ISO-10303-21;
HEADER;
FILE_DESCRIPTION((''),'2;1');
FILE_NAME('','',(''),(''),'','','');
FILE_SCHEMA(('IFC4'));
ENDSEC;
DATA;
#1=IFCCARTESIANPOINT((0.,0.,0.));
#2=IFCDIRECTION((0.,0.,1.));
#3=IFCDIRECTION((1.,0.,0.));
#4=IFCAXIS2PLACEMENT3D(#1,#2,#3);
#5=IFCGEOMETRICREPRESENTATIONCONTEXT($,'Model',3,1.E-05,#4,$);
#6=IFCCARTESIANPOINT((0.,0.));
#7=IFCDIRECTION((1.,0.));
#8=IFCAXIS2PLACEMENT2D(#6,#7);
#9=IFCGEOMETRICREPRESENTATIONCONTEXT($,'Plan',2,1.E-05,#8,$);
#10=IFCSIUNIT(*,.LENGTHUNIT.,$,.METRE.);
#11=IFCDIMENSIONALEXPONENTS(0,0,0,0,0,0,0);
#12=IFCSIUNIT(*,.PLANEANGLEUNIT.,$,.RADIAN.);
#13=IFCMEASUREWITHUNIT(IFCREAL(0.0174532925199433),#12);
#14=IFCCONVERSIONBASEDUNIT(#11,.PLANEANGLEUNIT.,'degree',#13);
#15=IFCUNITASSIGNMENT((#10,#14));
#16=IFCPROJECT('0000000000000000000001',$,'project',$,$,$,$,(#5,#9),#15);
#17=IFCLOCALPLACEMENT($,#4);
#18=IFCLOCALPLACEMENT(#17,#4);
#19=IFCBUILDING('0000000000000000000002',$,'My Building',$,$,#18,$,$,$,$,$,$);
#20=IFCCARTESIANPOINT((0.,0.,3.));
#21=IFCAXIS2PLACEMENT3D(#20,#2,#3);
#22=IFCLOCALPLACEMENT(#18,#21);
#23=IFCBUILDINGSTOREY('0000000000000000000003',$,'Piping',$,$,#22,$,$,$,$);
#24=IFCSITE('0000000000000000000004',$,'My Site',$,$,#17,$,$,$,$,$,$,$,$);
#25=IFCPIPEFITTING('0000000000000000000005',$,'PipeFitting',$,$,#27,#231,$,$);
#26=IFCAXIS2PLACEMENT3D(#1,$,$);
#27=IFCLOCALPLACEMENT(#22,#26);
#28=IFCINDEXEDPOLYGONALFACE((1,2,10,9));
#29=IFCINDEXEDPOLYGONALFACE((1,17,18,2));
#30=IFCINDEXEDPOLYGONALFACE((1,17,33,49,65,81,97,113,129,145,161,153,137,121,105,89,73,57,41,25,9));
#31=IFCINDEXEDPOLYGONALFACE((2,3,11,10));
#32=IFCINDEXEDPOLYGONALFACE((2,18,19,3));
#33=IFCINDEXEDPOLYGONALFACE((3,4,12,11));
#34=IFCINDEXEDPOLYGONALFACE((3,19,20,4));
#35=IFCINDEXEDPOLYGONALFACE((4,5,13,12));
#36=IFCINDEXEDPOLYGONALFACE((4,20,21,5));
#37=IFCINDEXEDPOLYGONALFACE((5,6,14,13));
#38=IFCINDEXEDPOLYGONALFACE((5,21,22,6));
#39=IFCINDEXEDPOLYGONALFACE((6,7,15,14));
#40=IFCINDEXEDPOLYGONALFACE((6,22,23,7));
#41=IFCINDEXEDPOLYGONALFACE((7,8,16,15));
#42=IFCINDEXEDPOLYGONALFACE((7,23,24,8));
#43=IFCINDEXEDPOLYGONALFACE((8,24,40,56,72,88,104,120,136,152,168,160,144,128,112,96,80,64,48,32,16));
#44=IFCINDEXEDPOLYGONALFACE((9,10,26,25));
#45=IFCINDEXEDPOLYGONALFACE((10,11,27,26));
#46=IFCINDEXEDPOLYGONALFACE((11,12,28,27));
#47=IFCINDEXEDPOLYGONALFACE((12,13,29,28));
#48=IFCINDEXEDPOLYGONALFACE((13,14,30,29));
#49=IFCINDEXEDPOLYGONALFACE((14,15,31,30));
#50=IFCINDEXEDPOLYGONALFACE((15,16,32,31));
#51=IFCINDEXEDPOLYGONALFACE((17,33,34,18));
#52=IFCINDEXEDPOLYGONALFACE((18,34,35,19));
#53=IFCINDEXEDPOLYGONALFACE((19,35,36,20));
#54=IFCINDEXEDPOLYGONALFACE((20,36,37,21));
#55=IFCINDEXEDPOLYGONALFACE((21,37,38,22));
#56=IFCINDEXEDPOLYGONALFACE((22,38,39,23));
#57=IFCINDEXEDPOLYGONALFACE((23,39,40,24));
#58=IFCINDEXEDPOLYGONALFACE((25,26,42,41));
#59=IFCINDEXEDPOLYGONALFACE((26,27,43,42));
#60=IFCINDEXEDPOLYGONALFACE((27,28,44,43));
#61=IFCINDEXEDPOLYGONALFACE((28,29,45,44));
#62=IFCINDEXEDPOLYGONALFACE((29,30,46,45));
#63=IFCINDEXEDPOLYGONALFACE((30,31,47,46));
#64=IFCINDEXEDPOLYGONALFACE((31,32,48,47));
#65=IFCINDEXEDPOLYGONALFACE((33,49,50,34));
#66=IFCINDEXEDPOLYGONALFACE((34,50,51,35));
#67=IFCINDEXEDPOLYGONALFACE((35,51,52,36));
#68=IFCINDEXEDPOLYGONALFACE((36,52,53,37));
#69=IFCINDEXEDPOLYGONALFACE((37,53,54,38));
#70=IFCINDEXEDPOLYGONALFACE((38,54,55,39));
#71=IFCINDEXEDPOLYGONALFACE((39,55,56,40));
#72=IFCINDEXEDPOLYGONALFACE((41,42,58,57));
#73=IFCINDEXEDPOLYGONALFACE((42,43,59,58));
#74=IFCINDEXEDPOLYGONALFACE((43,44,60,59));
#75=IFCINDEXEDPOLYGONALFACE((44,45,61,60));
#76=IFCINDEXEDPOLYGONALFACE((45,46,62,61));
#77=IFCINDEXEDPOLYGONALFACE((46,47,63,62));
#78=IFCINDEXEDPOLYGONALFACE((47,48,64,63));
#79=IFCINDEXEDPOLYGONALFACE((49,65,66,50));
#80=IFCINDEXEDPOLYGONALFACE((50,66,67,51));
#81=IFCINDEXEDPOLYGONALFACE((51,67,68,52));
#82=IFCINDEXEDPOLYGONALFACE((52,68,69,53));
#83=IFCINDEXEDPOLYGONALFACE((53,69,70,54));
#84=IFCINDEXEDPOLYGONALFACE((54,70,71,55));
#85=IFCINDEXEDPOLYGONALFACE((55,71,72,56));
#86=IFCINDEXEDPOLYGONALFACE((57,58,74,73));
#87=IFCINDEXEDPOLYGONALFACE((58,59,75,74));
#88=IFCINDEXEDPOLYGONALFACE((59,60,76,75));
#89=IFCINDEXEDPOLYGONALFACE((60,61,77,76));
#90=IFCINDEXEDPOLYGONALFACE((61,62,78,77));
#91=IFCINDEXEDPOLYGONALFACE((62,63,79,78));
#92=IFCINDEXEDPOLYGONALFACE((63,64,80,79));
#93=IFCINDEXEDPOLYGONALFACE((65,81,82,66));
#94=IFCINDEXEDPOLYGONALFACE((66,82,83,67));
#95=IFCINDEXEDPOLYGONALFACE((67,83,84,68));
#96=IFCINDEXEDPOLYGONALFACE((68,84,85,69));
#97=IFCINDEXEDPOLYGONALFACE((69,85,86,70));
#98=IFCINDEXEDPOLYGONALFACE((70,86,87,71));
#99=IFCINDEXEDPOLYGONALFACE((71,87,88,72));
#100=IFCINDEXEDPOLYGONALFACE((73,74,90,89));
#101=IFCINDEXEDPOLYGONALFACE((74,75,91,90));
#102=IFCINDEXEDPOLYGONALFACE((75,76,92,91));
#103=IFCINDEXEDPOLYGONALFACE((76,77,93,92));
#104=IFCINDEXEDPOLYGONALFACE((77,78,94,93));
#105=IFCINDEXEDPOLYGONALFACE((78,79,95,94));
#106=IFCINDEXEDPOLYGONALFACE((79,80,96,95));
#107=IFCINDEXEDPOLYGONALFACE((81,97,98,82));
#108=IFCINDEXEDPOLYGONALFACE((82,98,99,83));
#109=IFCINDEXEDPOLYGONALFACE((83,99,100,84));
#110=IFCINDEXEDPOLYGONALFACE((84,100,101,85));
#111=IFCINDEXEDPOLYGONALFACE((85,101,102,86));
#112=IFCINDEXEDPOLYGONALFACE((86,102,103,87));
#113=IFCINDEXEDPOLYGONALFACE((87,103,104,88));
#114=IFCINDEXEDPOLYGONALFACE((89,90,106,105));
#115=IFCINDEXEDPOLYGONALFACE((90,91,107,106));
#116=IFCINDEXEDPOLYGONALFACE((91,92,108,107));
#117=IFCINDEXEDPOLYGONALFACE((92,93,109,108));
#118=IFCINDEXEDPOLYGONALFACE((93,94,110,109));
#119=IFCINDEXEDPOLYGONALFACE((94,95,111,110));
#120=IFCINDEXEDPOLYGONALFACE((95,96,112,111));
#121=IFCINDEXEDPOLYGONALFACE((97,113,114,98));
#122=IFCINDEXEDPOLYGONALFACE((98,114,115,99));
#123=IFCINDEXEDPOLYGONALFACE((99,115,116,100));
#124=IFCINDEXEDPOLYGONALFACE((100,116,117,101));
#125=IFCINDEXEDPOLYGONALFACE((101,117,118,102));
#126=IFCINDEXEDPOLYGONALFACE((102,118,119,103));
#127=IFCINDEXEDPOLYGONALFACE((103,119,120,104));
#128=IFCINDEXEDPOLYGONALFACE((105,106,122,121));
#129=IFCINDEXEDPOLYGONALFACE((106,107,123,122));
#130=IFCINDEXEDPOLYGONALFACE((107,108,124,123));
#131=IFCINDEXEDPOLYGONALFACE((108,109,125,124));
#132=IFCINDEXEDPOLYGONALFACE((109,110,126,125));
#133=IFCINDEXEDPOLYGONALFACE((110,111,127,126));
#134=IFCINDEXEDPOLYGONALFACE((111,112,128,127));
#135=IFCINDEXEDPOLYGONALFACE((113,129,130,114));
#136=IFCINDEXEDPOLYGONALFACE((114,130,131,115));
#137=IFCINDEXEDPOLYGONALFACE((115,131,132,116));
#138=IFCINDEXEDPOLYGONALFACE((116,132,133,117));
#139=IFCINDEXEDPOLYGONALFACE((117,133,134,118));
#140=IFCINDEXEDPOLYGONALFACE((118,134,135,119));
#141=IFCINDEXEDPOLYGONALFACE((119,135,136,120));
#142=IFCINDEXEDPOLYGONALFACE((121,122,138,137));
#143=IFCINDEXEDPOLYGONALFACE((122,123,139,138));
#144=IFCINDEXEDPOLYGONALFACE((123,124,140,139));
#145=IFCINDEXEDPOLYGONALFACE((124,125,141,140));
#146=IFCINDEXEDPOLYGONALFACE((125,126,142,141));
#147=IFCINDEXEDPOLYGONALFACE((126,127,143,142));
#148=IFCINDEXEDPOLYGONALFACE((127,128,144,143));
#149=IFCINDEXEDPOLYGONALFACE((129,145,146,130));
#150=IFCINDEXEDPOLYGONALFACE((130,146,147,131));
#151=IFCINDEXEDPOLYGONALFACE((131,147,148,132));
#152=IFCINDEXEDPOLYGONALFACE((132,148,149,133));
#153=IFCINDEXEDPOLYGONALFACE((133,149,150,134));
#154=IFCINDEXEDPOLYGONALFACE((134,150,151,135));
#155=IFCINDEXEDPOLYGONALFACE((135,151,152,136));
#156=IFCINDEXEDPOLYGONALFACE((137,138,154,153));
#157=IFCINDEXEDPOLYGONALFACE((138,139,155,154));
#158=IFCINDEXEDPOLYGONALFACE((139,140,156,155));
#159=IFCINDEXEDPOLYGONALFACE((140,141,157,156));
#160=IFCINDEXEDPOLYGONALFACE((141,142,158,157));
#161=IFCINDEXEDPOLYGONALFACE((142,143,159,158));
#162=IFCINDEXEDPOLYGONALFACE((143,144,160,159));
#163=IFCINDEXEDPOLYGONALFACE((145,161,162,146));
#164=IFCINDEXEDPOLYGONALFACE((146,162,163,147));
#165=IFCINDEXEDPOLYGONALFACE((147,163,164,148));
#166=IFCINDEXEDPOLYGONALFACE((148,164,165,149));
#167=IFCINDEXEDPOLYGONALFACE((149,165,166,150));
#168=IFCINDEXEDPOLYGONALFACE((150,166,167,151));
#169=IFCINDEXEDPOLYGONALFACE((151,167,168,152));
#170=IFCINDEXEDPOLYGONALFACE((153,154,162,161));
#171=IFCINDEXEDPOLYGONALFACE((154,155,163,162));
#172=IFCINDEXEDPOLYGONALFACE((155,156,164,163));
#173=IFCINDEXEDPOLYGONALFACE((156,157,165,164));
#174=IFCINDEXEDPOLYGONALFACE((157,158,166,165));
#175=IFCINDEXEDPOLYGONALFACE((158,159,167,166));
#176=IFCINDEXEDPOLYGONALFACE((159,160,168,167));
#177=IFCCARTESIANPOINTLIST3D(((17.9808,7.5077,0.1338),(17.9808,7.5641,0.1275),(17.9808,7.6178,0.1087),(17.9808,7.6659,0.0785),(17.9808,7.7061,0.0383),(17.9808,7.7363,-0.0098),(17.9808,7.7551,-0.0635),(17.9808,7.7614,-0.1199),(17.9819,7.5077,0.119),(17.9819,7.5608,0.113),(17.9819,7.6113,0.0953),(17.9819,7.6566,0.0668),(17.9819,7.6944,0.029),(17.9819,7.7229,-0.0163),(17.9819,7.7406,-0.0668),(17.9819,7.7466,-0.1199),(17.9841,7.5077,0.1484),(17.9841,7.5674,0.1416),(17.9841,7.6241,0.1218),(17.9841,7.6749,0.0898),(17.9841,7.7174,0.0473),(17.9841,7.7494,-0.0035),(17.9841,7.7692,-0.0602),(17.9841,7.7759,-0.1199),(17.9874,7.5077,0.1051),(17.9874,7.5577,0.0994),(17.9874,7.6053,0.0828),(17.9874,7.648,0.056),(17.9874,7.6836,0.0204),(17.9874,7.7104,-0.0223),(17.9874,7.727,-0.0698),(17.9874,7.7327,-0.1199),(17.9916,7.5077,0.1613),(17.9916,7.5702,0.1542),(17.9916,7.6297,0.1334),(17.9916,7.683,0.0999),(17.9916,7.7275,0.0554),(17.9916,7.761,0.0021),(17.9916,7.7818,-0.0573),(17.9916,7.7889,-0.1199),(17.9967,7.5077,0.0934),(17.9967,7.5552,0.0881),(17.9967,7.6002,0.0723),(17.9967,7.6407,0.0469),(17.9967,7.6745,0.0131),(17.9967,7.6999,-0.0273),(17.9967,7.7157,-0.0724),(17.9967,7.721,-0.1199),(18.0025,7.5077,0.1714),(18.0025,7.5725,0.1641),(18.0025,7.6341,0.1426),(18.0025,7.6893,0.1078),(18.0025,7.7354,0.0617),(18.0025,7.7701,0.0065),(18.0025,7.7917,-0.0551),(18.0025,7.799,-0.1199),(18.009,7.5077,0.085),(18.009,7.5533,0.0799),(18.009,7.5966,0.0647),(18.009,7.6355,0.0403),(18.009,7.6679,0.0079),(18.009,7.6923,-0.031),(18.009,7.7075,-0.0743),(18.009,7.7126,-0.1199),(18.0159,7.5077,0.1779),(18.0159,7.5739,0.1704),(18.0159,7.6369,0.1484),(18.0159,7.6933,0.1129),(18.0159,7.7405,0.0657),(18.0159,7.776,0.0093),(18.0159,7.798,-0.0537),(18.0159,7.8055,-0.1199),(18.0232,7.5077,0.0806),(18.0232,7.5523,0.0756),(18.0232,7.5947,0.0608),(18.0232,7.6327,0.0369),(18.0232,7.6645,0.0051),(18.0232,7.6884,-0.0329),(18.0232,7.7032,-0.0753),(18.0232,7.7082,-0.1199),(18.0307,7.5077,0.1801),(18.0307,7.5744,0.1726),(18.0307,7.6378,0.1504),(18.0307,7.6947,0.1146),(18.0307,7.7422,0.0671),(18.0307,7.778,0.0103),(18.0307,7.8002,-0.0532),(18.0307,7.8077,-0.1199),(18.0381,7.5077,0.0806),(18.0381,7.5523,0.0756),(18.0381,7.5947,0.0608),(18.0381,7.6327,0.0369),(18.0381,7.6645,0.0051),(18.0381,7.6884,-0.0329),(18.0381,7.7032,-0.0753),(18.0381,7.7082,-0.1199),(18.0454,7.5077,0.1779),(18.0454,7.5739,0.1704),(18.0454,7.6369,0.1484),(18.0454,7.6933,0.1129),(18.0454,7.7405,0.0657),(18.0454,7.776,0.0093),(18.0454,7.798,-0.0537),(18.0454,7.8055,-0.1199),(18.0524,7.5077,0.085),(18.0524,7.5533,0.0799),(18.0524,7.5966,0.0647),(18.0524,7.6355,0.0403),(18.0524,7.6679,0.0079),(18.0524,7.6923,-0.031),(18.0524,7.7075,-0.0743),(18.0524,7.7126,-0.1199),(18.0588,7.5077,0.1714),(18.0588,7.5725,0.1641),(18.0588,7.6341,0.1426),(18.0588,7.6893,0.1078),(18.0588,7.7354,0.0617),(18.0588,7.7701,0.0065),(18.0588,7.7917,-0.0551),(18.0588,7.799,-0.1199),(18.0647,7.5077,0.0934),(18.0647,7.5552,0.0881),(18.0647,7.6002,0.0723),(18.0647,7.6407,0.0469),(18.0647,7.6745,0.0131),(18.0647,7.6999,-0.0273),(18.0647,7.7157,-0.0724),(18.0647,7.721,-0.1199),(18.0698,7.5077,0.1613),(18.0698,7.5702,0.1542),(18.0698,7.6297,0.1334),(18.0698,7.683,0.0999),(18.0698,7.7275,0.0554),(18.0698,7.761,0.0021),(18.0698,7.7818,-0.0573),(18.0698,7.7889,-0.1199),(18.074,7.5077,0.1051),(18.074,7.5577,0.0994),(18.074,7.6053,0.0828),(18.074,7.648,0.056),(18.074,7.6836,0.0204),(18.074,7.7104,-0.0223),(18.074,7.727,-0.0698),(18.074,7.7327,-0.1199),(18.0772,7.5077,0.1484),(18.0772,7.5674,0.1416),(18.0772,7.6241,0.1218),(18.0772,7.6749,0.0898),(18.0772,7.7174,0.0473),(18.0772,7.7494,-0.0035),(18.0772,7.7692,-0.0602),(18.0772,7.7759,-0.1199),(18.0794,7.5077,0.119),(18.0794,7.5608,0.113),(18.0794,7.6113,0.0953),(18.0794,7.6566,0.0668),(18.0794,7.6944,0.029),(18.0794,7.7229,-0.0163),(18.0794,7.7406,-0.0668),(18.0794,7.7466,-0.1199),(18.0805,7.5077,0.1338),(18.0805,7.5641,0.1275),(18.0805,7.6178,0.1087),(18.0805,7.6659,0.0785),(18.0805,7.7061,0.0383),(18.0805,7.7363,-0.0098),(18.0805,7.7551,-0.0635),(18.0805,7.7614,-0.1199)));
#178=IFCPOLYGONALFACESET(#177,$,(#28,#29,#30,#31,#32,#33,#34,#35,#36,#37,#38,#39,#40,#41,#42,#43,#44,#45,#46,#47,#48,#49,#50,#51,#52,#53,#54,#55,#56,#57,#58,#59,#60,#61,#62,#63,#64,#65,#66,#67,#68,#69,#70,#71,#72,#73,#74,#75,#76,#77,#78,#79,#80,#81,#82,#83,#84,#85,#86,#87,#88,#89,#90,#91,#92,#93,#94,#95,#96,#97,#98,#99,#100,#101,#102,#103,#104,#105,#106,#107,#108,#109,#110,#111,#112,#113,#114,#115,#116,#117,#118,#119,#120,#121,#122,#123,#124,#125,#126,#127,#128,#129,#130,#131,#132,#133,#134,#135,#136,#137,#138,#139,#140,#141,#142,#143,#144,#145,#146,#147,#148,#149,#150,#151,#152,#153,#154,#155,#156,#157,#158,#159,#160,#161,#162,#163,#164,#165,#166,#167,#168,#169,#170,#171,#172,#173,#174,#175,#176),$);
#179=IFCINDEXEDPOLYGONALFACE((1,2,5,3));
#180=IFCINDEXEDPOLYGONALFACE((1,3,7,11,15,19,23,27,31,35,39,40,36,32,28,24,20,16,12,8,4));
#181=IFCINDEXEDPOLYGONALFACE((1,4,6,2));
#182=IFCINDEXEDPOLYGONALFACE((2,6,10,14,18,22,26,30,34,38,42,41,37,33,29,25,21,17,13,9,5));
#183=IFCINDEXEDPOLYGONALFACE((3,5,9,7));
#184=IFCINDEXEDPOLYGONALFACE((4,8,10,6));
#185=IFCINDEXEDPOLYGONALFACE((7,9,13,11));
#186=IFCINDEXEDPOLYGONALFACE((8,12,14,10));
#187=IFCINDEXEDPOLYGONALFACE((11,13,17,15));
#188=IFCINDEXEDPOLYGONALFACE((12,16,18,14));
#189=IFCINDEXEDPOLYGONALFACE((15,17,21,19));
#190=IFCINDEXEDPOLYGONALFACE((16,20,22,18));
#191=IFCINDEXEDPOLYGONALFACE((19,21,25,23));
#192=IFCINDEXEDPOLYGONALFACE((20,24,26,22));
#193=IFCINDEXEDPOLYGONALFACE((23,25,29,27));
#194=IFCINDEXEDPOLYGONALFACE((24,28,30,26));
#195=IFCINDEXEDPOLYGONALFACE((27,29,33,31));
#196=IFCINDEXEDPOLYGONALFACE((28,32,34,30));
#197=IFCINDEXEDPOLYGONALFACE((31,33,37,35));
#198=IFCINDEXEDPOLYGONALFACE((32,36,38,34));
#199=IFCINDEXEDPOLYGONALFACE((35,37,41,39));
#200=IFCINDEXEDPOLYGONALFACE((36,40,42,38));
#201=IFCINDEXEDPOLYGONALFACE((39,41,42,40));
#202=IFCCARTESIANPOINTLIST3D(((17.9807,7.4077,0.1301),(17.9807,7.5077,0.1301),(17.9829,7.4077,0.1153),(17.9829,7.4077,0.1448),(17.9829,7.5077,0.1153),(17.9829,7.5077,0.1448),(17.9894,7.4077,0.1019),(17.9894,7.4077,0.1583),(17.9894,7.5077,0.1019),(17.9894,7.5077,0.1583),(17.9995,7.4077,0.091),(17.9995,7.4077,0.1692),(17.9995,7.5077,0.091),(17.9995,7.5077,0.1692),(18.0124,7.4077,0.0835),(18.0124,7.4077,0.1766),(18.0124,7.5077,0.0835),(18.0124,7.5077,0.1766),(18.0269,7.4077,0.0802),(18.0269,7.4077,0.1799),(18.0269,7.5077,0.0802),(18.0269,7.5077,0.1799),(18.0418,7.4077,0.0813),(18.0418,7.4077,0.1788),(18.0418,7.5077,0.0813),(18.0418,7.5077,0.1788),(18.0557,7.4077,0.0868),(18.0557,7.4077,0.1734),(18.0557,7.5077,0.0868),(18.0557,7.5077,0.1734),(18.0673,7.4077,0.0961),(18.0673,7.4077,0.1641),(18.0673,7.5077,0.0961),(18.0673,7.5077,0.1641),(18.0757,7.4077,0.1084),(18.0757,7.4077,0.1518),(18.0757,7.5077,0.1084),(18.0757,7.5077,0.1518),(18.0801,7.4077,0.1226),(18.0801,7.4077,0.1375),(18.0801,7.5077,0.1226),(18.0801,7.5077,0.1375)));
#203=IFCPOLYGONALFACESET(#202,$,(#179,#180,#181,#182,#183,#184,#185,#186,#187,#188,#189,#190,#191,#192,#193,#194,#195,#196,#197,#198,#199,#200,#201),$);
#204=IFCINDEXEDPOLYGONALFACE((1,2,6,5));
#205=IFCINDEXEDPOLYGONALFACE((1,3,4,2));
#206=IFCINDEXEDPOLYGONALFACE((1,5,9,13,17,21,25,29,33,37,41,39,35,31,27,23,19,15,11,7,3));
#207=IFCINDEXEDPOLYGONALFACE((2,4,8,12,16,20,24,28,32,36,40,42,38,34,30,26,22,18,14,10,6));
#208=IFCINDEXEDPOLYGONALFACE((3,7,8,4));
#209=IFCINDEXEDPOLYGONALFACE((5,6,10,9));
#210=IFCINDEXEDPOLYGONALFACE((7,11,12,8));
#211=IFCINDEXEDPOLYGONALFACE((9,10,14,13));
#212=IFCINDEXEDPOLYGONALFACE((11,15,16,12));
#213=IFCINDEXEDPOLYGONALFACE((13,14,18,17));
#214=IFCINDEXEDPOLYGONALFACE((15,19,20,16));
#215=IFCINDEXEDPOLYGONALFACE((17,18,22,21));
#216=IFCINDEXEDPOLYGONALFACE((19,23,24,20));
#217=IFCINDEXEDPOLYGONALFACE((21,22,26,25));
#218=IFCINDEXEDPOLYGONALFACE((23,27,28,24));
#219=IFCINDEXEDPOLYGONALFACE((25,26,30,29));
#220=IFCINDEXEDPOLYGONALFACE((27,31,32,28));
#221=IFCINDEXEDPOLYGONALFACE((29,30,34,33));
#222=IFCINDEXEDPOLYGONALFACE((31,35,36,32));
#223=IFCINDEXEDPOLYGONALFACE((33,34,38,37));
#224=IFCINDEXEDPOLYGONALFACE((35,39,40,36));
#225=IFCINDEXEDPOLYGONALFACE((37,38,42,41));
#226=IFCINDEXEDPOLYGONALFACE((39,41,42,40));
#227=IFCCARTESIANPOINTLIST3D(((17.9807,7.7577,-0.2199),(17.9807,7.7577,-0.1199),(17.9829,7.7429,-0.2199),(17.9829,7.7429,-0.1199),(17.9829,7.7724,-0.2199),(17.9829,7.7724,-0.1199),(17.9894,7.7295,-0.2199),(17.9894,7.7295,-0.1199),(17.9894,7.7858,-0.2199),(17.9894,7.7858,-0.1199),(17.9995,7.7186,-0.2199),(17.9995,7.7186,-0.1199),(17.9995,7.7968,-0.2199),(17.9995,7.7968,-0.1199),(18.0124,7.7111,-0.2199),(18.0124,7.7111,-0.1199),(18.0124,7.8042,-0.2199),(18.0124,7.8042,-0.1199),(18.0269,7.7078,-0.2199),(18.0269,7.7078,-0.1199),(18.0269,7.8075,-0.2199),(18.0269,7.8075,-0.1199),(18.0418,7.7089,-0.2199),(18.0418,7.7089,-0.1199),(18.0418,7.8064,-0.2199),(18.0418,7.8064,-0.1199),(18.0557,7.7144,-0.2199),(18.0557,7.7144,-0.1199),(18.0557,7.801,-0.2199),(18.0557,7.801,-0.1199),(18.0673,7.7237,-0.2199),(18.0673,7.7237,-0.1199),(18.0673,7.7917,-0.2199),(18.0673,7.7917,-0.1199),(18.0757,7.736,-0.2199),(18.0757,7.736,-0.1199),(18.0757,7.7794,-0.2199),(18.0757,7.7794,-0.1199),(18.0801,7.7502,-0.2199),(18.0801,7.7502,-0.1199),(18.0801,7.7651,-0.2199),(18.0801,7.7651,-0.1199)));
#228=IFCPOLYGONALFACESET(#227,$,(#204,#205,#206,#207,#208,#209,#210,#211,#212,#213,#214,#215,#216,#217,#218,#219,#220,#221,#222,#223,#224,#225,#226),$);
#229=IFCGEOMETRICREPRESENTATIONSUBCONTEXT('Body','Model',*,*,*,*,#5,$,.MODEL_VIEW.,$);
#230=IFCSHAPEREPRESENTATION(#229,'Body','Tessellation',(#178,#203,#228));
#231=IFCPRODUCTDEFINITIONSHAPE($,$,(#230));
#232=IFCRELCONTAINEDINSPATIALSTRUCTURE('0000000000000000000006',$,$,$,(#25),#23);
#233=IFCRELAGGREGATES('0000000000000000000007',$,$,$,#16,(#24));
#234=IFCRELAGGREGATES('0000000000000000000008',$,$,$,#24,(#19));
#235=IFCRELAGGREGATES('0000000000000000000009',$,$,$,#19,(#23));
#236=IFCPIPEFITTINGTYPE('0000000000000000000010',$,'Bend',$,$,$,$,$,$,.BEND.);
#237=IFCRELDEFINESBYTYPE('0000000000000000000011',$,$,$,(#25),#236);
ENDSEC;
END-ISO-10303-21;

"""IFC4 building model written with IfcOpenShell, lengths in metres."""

from ifc_helpers import new_model, entity, si_unit, converted_unit, frame, origin_with_axes, origin_2d_with_axis, place, context, subcontext, project, spatial, circle, extrude, source, transform, mapped, type_object, type_shapes, element, save


model = new_model("IFC4")

# Units and contexts
model_context = context("Model", 3, precision=1e-05, world=origin_with_axes())
plan_context = context("Plan", 2, precision=1e-05, world=origin_2d_with_axis())
body_context = subcontext(model_context, "Body", "Model", "MODEL_VIEW")
ifc_project = project(units=[si_unit("LENGTHUNIT", "METRE"), converted_unit("PLANEANGLEUNIT", "degree", entity("IfcReal", 0.0174532925199433), si_unit("PLANEANGLEUNIT", "RADIAN"), dimensions=[0, 0, 0, 0, 0, 0, 0])], contexts=[model_context, plan_context])

# Site, building, storey
site_placement = place(None, origin_with_axes())
site = spatial("IfcSite", under=ifc_project, at=site_placement, Name="My Site")
building_placement = place(site_placement, origin_with_axes())
building = spatial("IfcBuilding", under=site, at=building_placement, Name="My Building")
storey_placement = place(building_placement, frame((0.0, 0.0, 3.0), z_axis=(0.0, 0.0, 1.0), x_axis=(1.0, 0.0, 0.0)))
storey = spatial("IfcBuildingStorey", under=building, at=storey_placement, Name="Piping")

# Pipe fitting
pipe_fitting_type_1 = type_object("IfcPipeFittingType", Name="Bend", PredefinedType="BEND")
shared_shape_1 = source(origin_with_axes(), body_context, "Body", "SolidModel", [
    entity("IfcSweptDiskSolid", entity("IfcIndexedPolyCurve", entity("IfcCartesianPointList3D", [[0.0, 0.0, 0.1], [0.0, -0.0732, 0.2768], [0.0, -0.25, 0.35]]), [entity("IfcArcIndex", [1, 2, 3])]), 0.05),
    extrude(circle(Radius=0.05), origin_with_axes(), (0.0, 0.0, 1.0), 0.1),
    extrude(circle(Radius=0.05), frame((0.0, -0.25, 0.35), z_axis=(0.0, -1.0, -0.000015), x_axis=(1.0, 0.0, 0.0)), (0.0, 0.0, 1.0), 0.1),
])
type_shapes(pipe_fitting_type_1, [shared_shape_1])
for number, where, z_axis, x_axis, name in (
    (1, (18.0307, 7.4077, 0.1301), (0.0, 1.0, 0.000015), (-1.0, 0.0, 0.0), "PipeFitting"),
):
    element("IfcPipeFitting", number, at=place(storey_placement, frame(where, z_axis=z_axis, x_axis=x_axis)), inside=storey, type_object=pipe_fitting_type_1, Name=name, context=body_context, shape_type="MappedRepresentation", body=[
        mapped(shared_shape_1, transform((0.0, 0.0, 0.0), x_axis=(1.0, 0.0, 0.0), y_axis=(0.0, 1.0, 0.0), z_axis=(0.0, 0.0, 1.0), scale=1.0)),
    ])

save(model, "model.ifc")
